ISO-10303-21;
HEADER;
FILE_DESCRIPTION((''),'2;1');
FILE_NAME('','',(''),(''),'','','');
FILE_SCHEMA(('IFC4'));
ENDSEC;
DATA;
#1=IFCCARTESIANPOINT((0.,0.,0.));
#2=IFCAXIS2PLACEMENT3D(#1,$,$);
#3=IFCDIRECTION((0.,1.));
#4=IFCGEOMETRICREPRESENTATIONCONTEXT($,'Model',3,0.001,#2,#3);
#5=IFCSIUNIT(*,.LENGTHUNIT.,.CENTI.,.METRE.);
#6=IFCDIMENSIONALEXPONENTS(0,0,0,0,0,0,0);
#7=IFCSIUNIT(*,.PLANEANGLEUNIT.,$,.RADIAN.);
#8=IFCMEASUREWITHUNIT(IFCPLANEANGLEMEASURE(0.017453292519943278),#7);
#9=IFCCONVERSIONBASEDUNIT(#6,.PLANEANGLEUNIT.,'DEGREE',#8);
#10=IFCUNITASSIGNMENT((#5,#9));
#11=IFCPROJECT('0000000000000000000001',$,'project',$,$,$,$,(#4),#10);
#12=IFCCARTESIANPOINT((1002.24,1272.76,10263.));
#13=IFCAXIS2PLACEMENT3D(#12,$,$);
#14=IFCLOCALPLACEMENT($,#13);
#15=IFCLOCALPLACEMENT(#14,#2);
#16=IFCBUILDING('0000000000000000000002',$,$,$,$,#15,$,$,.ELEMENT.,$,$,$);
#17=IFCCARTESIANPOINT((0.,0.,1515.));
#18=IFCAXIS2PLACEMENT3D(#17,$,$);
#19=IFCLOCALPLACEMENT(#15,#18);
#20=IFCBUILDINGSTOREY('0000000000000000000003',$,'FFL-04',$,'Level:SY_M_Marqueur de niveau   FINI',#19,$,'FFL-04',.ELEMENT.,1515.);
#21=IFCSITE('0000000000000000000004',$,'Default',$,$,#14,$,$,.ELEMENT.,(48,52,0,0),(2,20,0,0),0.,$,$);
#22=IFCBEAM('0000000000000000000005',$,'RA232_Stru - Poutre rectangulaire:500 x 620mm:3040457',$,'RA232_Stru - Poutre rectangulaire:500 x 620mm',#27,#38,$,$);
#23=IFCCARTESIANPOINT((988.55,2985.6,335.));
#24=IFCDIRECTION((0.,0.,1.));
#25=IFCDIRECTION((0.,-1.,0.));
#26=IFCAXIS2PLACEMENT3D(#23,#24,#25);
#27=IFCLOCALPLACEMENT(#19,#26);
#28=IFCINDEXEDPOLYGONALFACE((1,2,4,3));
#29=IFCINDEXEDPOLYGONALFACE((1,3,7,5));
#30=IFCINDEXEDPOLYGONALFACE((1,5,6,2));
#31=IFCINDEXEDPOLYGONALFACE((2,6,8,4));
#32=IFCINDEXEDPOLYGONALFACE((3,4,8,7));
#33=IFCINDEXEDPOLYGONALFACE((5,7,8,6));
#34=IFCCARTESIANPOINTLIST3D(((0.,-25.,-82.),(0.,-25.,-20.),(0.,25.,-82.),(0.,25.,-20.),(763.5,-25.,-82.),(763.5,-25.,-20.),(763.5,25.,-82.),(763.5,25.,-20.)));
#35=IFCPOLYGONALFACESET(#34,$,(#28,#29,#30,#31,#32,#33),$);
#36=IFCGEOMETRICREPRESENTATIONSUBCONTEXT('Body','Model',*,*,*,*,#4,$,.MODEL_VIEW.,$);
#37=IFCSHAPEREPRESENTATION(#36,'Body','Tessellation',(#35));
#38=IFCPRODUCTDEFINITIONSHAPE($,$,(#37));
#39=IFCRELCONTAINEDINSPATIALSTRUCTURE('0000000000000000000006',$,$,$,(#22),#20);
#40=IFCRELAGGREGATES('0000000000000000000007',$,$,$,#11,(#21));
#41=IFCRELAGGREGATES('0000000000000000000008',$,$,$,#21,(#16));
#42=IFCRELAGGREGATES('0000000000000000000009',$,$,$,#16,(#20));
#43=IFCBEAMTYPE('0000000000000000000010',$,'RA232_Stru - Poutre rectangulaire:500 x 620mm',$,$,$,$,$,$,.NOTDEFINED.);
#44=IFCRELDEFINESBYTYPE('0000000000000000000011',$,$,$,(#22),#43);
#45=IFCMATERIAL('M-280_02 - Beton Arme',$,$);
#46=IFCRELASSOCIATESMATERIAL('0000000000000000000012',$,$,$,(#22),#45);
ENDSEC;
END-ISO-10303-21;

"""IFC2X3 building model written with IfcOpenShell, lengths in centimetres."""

from ifc_helpers import new_model, entity, si_unit, converted_unit, direction, frame, frame_2d, origin, place, context, subcontext, project, spatial, rectangle, extrude, material, type_object, element, save


model = new_model("IFC2X3")

# Units and contexts
model_context = context("Model", 3, precision=0.001, world=origin(), true_north=direction((0.0, 1.0)))
body_context = subcontext(model_context, "Body", "Model", "MODEL_VIEW")
ifc_project = project(units=[si_unit("LENGTHUNIT", "METRE", prefix="CENTI"), converted_unit("PLANEANGLEUNIT", "DEGREE", entity("IfcPlaneAngleMeasure", 0.017453292519943278), si_unit("PLANEANGLEUNIT", "RADIAN"), dimensions=[0, 0, 0, 0, 0, 0, 0])], contexts=[model_context])

# Site, building, storey
site_placement = place(None, frame((1002.24, 1272.76, 10263.0)))
site = spatial("IfcSite", under=ifc_project, at=site_placement, Name="Default", CompositionType="ELEMENT", RefLatitude=(48, 52, 0, 0), RefLongitude=(2, 20, 0, 0), RefElevation=0.0)
building_placement = place(site_placement, origin())
building = spatial("IfcBuilding", under=site, at=building_placement, CompositionType="ELEMENT")
storey_placement = place(building_placement, frame((0.0, 0.0, 1515.0)))
storey = spatial("IfcBuildingStorey", under=building, at=storey_placement, Name="FFL-04", ObjectType="Level:SY_M_Marqueur de niveau   FINI", LongName="FFL-04", CompositionType="ELEMENT", Elevation=1515.0)

# Beam
ifc_material_1 = material(Name="M-280_02 - Beton Arme")
beam_type = type_object("IfcBeamType", Name="RA232_Stru - Poutre rectangulaire:500 x 620mm", PredefinedType="NOTDEFINED")
beam_placement = place(storey_placement, frame((988.55, 2985.6, 335.0), z_axis=(0.0, 0.0, 1.0), x_axis=(0.0, -1.0, 0.0)))
element("IfcBeam", 1, at=beam_placement, inside=storey, type_object=beam_type, material=ifc_material_1, Name="RA232_Stru - Poutre rectangulaire:500 x 620mm:3040457", ObjectType="RA232_Stru - Poutre rectangulaire:500 x 620mm", context=body_context, shape_type="SweptSolid", body=[
    extrude(rectangle(XDim=62.0, YDim=50.0, at=frame_2d((0.0, 0.0), x_axis=(1.0, 0.0))), frame((0.0, 0.0, -51.0), z_axis=(1.0, 0.0, 0.0), x_axis=(0.0, 0.0, -1.0)), (0.0, 0.0, 1.0), 763.5),
])

save(model, "model.ifc")
